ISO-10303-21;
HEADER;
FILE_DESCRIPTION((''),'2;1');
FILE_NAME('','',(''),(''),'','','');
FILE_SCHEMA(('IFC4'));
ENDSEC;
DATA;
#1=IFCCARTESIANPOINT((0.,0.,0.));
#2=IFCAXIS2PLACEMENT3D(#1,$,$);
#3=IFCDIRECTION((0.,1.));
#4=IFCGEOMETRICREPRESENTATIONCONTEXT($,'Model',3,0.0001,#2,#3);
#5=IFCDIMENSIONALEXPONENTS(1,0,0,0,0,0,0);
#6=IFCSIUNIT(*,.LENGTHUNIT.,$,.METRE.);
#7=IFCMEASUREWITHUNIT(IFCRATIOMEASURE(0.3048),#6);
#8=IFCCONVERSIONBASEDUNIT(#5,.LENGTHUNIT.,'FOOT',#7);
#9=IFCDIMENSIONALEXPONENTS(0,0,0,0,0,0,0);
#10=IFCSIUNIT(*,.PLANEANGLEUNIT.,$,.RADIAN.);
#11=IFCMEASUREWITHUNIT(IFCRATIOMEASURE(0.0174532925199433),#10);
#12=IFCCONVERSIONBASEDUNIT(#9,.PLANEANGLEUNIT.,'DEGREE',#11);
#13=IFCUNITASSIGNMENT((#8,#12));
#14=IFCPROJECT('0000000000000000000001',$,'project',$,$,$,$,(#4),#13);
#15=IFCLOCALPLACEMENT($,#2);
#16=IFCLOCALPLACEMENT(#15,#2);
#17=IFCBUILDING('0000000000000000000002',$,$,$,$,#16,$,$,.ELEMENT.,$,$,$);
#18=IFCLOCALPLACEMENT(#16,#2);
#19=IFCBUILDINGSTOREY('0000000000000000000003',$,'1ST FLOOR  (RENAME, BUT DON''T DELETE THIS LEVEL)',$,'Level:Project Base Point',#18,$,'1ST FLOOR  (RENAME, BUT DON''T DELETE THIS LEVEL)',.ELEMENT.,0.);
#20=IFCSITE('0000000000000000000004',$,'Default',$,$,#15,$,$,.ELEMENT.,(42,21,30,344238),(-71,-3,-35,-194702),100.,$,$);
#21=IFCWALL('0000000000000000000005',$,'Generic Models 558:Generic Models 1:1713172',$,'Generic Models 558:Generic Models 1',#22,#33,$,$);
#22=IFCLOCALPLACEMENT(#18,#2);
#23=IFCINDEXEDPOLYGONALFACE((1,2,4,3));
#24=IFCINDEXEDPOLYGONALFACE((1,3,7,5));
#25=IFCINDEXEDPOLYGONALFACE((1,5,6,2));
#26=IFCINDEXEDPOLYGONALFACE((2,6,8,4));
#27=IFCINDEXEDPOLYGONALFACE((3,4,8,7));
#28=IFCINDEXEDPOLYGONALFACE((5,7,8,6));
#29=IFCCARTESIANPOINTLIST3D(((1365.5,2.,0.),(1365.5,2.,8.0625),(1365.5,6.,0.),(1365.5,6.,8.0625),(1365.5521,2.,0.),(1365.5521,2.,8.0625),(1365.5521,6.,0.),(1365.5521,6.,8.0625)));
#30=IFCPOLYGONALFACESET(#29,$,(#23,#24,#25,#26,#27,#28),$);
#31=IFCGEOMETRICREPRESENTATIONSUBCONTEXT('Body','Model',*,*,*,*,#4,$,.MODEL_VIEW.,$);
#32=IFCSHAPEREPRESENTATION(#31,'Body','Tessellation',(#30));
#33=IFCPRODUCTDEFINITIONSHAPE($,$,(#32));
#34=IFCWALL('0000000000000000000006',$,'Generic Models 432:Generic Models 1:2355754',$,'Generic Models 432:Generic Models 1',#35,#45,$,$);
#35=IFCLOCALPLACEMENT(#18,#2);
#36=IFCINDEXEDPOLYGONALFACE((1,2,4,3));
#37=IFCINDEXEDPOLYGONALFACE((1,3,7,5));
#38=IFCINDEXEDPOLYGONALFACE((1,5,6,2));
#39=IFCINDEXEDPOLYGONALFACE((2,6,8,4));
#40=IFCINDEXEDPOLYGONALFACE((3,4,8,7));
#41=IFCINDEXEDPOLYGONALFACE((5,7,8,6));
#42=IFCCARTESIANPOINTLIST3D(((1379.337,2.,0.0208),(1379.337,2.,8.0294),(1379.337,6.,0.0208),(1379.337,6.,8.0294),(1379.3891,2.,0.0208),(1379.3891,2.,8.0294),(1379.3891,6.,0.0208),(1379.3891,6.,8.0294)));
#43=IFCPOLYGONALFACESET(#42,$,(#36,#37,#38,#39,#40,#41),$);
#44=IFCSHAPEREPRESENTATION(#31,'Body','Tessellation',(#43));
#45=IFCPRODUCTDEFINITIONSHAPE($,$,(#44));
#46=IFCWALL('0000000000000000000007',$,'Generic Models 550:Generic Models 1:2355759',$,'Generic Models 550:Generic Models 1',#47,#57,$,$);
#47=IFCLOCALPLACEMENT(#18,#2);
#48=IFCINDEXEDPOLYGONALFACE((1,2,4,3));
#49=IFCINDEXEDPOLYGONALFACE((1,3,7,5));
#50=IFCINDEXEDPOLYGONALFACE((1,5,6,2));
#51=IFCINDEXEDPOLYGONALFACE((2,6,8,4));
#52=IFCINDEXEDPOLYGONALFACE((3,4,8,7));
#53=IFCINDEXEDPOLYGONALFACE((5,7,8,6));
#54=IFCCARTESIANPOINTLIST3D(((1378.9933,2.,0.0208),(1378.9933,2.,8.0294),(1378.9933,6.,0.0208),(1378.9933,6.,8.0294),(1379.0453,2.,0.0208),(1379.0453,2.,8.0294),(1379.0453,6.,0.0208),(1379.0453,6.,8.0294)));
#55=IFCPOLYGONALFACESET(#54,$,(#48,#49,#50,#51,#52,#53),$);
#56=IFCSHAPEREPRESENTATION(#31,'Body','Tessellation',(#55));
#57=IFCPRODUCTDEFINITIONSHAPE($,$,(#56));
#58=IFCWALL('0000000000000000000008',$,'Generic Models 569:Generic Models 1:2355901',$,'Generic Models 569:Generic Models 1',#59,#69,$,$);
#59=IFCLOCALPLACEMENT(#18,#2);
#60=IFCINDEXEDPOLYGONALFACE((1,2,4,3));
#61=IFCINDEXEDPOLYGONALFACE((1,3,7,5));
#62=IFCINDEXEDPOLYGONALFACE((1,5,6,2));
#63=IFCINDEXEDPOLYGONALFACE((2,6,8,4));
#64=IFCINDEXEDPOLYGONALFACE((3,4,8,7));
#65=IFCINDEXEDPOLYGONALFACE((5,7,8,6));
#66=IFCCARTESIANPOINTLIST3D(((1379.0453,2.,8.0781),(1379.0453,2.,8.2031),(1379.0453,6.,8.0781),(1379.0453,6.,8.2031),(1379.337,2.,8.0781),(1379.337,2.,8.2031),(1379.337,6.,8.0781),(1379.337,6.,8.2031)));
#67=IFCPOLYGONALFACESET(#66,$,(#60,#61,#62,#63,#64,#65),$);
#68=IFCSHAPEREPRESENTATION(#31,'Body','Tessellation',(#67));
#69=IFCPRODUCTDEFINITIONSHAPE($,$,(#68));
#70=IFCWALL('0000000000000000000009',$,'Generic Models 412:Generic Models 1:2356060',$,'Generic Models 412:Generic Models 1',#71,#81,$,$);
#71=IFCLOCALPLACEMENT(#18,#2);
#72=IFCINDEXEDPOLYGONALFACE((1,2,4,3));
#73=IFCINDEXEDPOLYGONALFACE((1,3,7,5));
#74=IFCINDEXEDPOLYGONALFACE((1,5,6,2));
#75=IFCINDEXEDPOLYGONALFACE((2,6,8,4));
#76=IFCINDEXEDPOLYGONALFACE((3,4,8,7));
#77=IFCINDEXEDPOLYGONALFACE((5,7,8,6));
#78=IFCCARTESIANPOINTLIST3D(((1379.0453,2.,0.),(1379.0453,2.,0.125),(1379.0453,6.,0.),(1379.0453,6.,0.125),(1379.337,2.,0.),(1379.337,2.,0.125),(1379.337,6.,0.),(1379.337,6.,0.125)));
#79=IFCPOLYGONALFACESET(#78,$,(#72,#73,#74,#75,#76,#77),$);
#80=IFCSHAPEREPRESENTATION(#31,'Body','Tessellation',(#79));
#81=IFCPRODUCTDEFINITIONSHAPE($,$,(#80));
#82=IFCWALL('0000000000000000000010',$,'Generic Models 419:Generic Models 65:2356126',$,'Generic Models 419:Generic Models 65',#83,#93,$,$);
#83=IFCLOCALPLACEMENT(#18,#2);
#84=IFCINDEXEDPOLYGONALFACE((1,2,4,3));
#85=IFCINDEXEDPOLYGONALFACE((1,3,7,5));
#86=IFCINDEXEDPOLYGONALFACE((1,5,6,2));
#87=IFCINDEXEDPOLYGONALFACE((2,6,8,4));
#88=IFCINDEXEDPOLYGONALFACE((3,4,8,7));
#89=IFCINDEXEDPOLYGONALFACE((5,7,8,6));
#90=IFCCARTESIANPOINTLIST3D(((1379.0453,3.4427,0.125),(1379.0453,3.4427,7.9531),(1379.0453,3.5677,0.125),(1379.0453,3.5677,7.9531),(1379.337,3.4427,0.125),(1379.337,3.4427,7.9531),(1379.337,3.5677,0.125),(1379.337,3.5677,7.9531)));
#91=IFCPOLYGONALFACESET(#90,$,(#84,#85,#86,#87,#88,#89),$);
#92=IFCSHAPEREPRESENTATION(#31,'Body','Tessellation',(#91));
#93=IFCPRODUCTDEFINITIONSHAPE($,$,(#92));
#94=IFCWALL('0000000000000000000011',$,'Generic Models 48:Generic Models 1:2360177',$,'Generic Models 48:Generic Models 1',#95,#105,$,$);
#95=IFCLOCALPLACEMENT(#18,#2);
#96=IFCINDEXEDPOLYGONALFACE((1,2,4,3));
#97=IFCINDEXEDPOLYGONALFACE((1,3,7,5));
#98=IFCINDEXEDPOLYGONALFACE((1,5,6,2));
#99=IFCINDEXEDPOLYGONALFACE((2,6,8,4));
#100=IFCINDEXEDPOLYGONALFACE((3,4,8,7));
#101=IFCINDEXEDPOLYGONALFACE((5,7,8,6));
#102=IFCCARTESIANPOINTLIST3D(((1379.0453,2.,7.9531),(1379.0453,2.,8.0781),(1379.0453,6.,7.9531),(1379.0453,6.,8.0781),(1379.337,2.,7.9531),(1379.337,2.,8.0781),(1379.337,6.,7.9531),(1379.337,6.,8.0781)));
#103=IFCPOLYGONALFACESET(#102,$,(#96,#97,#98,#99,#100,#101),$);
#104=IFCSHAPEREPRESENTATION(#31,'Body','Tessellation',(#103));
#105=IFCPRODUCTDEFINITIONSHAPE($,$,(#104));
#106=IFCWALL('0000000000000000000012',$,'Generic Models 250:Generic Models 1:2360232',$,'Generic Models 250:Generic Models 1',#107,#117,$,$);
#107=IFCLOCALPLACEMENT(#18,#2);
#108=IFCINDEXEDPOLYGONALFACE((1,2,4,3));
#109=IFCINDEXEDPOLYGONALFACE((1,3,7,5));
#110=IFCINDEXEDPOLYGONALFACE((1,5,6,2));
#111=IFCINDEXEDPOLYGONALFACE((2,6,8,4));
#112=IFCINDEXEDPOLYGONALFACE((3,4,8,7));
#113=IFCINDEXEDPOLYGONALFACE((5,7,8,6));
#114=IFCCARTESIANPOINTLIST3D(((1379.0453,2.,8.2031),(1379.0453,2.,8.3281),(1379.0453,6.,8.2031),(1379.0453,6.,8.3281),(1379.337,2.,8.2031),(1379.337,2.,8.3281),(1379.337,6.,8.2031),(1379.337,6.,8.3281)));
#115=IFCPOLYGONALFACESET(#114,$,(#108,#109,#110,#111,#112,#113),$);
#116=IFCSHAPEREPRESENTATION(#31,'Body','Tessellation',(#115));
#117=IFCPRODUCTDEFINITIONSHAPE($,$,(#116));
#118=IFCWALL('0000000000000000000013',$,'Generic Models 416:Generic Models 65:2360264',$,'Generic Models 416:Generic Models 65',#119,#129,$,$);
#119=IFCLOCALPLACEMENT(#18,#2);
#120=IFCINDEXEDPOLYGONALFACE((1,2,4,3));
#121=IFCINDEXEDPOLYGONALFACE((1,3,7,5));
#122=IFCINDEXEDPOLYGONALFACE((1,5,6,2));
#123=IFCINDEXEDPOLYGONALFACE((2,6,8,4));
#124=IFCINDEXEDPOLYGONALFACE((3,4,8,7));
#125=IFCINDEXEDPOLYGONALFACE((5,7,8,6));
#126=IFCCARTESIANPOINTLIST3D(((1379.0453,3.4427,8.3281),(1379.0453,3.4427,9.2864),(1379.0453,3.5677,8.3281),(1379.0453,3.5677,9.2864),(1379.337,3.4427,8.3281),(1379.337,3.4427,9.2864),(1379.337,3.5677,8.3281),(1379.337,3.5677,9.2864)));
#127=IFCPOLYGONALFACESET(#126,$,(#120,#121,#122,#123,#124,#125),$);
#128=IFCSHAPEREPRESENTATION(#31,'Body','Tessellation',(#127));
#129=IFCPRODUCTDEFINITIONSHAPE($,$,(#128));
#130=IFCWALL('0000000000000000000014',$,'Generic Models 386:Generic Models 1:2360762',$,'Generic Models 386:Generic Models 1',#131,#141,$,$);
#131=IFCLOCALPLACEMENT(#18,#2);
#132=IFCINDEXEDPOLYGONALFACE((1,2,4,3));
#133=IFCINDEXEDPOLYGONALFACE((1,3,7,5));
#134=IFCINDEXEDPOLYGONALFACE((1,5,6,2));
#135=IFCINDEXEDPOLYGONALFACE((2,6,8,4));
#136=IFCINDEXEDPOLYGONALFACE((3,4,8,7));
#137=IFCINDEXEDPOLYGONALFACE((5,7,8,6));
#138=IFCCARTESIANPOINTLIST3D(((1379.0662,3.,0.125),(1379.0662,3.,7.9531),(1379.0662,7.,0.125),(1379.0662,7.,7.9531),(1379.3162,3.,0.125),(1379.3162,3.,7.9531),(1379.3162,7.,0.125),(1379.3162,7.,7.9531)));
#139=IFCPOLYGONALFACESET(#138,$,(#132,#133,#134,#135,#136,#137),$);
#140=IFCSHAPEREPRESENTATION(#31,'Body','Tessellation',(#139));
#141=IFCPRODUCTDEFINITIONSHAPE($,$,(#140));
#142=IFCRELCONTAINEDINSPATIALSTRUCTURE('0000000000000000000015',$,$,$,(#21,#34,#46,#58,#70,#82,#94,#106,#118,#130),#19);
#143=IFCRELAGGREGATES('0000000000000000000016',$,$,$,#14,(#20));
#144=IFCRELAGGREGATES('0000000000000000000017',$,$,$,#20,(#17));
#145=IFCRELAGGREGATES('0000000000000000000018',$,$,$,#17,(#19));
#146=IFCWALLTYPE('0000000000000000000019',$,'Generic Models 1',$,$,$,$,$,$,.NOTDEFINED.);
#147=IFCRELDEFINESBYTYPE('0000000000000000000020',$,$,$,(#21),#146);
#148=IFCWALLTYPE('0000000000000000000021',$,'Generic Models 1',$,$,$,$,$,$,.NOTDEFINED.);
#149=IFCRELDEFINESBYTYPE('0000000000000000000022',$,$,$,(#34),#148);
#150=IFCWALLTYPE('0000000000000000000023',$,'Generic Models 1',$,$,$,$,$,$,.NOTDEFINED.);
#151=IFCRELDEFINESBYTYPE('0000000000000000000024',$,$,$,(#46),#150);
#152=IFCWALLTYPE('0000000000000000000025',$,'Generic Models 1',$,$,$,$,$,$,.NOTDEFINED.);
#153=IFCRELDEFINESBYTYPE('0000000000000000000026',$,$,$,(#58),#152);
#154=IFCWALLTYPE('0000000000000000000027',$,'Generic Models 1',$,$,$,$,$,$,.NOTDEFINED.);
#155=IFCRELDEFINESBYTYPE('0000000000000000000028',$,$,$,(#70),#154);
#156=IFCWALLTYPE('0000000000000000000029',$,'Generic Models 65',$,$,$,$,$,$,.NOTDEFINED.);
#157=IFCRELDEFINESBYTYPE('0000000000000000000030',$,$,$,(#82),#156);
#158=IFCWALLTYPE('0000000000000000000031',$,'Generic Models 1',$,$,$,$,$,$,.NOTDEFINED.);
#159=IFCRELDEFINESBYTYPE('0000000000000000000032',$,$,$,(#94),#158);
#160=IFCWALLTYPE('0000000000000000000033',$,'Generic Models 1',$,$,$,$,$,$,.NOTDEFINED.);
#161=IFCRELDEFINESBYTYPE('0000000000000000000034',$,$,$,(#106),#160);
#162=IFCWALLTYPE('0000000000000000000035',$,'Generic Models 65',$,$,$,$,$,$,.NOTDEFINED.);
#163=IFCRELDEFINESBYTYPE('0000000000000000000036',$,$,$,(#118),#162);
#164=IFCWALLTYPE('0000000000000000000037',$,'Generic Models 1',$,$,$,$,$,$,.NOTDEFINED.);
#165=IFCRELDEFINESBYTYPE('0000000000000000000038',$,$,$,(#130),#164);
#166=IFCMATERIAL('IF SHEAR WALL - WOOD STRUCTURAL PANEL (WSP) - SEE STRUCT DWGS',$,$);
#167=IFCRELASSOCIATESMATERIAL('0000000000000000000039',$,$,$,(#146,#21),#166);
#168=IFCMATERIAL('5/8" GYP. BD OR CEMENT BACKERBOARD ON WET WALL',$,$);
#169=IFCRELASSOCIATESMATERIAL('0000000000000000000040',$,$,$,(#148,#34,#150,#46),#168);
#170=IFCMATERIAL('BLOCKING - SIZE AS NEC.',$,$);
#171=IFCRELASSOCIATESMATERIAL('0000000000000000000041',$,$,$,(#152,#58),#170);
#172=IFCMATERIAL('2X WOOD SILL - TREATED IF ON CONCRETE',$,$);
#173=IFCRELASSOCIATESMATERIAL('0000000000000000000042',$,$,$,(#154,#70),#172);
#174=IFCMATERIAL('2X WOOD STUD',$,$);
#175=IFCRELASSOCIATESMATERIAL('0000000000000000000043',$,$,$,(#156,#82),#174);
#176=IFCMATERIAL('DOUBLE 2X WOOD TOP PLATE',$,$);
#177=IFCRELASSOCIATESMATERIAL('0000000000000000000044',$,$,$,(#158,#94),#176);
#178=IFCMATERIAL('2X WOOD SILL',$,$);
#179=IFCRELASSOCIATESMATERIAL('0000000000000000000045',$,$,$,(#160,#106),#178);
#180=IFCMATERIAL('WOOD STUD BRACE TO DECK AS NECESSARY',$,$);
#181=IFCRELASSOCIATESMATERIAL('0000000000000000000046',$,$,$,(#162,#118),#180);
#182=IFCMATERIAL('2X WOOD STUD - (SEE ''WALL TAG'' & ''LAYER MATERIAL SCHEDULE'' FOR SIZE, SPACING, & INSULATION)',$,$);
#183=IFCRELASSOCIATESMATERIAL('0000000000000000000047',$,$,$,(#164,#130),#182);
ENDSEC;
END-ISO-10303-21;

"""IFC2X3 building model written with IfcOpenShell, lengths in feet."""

from ifc_helpers import new_model, entity, si_unit, converted_unit, direction, frame, frame_2d, origin, place, context, subcontext, project, spatial, rectangle, extrude, material, type_object, element, save


model = new_model("IFC2X3")

# Units and contexts
model_context = context("Model", 3, precision=0.0001, world=origin(), true_north=direction((0.0, 1.0)))
body_context = subcontext(model_context, "Body", "Model", "MODEL_VIEW")
ifc_project = project(units=[converted_unit("LENGTHUNIT", "FOOT", entity("IfcRatioMeasure", 0.3048), si_unit("LENGTHUNIT", "METRE"), dimensions=[1, 0, 0, 0, 0, 0, 0]), converted_unit("PLANEANGLEUNIT", "DEGREE", entity("IfcRatioMeasure", 0.0174532925199433), si_unit("PLANEANGLEUNIT", "RADIAN"), dimensions=[0, 0, 0, 0, 0, 0, 0])], contexts=[model_context])

# Site, building, storey
site_placement = place(None, origin())
site = spatial("IfcSite", under=ifc_project, at=site_placement, Name="Default", CompositionType="ELEMENT", RefLatitude=(42, 21, 30, 344238), RefLongitude=(-71, -3, -35, -194702), RefElevation=100.0)
building_placement = place(site_placement, origin())
building = spatial("IfcBuilding", under=site, at=building_placement, CompositionType="ELEMENT")
storey_placement = place(building_placement, origin())
storey = spatial("IfcBuildingStorey", under=building, at=storey_placement, Name="1ST FLOOR  (RENAME, BUT DON'T DELETE THIS LEVEL)", ObjectType="Level:Project Base Point", LongName="1ST FLOOR  (RENAME, BUT DON'T DELETE THIS LEVEL)", CompositionType="ELEMENT", Elevation=0.0)

# Walls
ifc_material_1 = material(Name="2X WOOD SILL - TREATED IF ON CONCRETE")
ifc_material_2 = material(Name="5/8\" GYP. BD OR CEMENT BACKERBOARD ON WET WALL")
ifc_material_3 = material(Name="2X WOOD STUD")
ifc_material_4 = material(Name="DOUBLE 2X WOOD TOP PLATE")
ifc_material_5 = material(Name="2X WOOD STUD - (SEE 'WALL TAG' & 'LAYER MATERIAL SCHEDULE' FOR SIZE, SPACING, & INSULATION)")
ifc_material_6 = material(Name="IF SHEAR WALL - WOOD STRUCTURAL PANEL (WSP) - SEE STRUCT DWGS")
wall_type_1 = type_object("IfcWallType", Name="Generic Models 1", PredefinedType="NOTDEFINED", material=ifc_material_6)
wall_1_placement = place(storey_placement, frame((1365.5, 2.0, 0.0), z_axis=(0.0, 0.0, 1.0), x_axis=(0.0, 1.0, 0.0)))
element("IfcWall", 1, at=wall_1_placement, inside=storey, type_object=wall_type_1, material=ifc_material_6, Name="Generic Models 558:Generic Models 1:1713172", ObjectType="Generic Models 558:Generic Models 1", context=body_context, shape_type="SweptSolid", body=[
    extrude(rectangle(XDim=4.0, YDim=0.0521, at=frame_2d((0.0, 0.0), x_axis=(1.0, 0.0))), frame((2.0, -0.026, 0.0)), (0.0, 0.0, 1.0), 8.0625),
])
wall_type_2 = type_object("IfcWallType", Name="Generic Models 1", PredefinedType="NOTDEFINED", material=ifc_material_2)
wall_2_placement = place(storey_placement, frame((1379.337, 2.0, 0.0208), z_axis=(0.0, 0.0, 1.0), x_axis=(0.0, 1.0, 0.0)))
element("IfcWall", 2, at=wall_2_placement, inside=storey, type_object=wall_type_2, material=ifc_material_2, Name="Generic Models 432:Generic Models 1:2355754", ObjectType="Generic Models 432:Generic Models 1", context=body_context, shape_type="SweptSolid", body=[
    extrude(rectangle(XDim=4.0, YDim=0.0521, at=frame_2d((0.0, 0.0), x_axis=(1.0, 0.0))), frame((2.0, -0.026, 0.0)), (0.0, 0.0, 1.0), 8.0086),
])
wall_type_3 = type_object("IfcWallType", Name="Generic Models 1", PredefinedType="NOTDEFINED", material=ifc_material_2)
wall_3_placement = place(storey_placement, frame((1378.9932, 2.0, 0.0208), z_axis=(0.0, 0.0, 1.0), x_axis=(0.0, 1.0, 0.0)))
element("IfcWall", 3, at=wall_3_placement, inside=storey, type_object=wall_type_3, material=ifc_material_2, Name="Generic Models 550:Generic Models 1:2355759", ObjectType="Generic Models 550:Generic Models 1", context=body_context, shape_type="SweptSolid", body=[
    extrude(rectangle(XDim=4.0, YDim=0.0521, at=frame_2d((0.0, 0.0), x_axis=(1.0, 0.0))), frame((2.0, -0.026, 0.0)), (0.0, 0.0, 1.0), 8.0086),
])
ifc_material_7 = material(Name="BLOCKING - SIZE AS NEC.")
wall_type_4 = type_object("IfcWallType", Name="Generic Models 1", PredefinedType="NOTDEFINED", material=ifc_material_7)
wall_4_placement = place(storey_placement, frame((1379.0453, 2.0, 8.0781), z_axis=(0.0, 0.0, 1.0), x_axis=(0.0, 1.0, 0.0)))
element("IfcWall", 4, at=wall_4_placement, inside=storey, type_object=wall_type_4, material=ifc_material_7, Name="Generic Models 569:Generic Models 1:2355901", ObjectType="Generic Models 569:Generic Models 1", context=body_context, shape_type="SweptSolid", body=[
    extrude(rectangle(XDim=4.0, YDim=0.2917, at=frame_2d((0.0, 0.0), x_axis=(1.0, 0.0))), frame((2.0, -0.1458, 0.0)), (0.0, 0.0, 1.0), 0.125),
])
wall_type_5 = type_object("IfcWallType", Name="Generic Models 1", PredefinedType="NOTDEFINED", material=ifc_material_1)
wall_5_placement = place(storey_placement, frame((1379.0453, 2.0, 0.0), z_axis=(0.0, 0.0, 1.0), x_axis=(0.0, 1.0, 0.0)))
element("IfcWall", 5, at=wall_5_placement, inside=storey, type_object=wall_type_5, material=ifc_material_1, Name="Generic Models 412:Generic Models 1:2356060", ObjectType="Generic Models 412:Generic Models 1", context=body_context, shape_type="SweptSolid", body=[
    extrude(rectangle(XDim=4.0, YDim=0.2917, at=frame_2d((0.0, 0.0), x_axis=(1.0, 0.0))), frame((2.0, -0.1458, 0.0)), (0.0, 0.0, 1.0), 0.125),
])
wall_type_6 = type_object("IfcWallType", Name="Generic Models 65", PredefinedType="NOTDEFINED", material=ifc_material_3)
wall_6_placement = place(storey_placement, frame((1379.0453, 3.4427, 0.125)))
element("IfcWall", 6, at=wall_6_placement, inside=storey, type_object=wall_type_6, material=ifc_material_3, Name="Generic Models 419:Generic Models 65:2356126", ObjectType="Generic Models 419:Generic Models 65", context=body_context, shape_type="SweptSolid", body=[
    extrude(rectangle(XDim=0.125, YDim=0.2917, at=frame_2d((0.0, 0.0), x_axis=(1.0, 0.0))), frame((0.1458, 0.0625, 0.0), z_axis=(0.0, 0.0, 1.0), x_axis=(0.0, 1.0, 0.0)), (0.0, 0.0, 1.0), 7.8281),
])
wall_type_7 = type_object("IfcWallType", Name="Generic Models 1", PredefinedType="NOTDEFINED", material=ifc_material_4)
wall_7_placement = place(storey_placement, frame((1379.0453, 2.0, 7.9531), z_axis=(0.0, 0.0, 1.0), x_axis=(0.0, 1.0, 0.0)))
element("IfcWall", 7, at=wall_7_placement, inside=storey, type_object=wall_type_7, material=ifc_material_4, Name="Generic Models 48:Generic Models 1:2360177", ObjectType="Generic Models 48:Generic Models 1", context=body_context, shape_type="SweptSolid", body=[
    extrude(rectangle(XDim=4.0, YDim=0.2917, at=frame_2d((0.0, 0.0), x_axis=(1.0, 0.0))), frame((2.0, -0.1458, 0.0)), (0.0, 0.0, 1.0), 0.125),
])
ifc_material_8 = material(Name="2X WOOD SILL")
wall_type_8 = type_object("IfcWallType", Name="Generic Models 1", PredefinedType="NOTDEFINED", material=ifc_material_8)
wall_8_placement = place(storey_placement, frame((1379.0453, 2.0, 8.2031), z_axis=(0.0, 0.0, 1.0), x_axis=(0.0, 1.0, 0.0)))
element("IfcWall", 8, at=wall_8_placement, inside=storey, type_object=wall_type_8, material=ifc_material_8, Name="Generic Models 250:Generic Models 1:2360232", ObjectType="Generic Models 250:Generic Models 1", context=body_context, shape_type="SweptSolid", body=[
    extrude(rectangle(XDim=4.0, YDim=0.2917, at=frame_2d((0.0, 0.0), x_axis=(1.0, 0.0))), frame((2.0, -0.1458, 0.0)), (0.0, 0.0, 1.0), 0.125),
])
ifc_material_9 = material(Name="WOOD STUD BRACE TO DECK AS NECESSARY")
wall_type_9 = type_object("IfcWallType", Name="Generic Models 65", PredefinedType="NOTDEFINED", material=ifc_material_9)
wall_9_placement = place(storey_placement, frame((1379.0453, 3.4427, 8.3281)))
element("IfcWall", 9, at=wall_9_placement, inside=storey, type_object=wall_type_9, material=ifc_material_9, Name="Generic Models 416:Generic Models 65:2360264", ObjectType="Generic Models 416:Generic Models 65", context=body_context, shape_type="SweptSolid", body=[
    extrude(rectangle(XDim=0.125, YDim=0.2917, at=frame_2d((0.0, 0.0), x_axis=(1.0, 0.0))), frame((0.1458, 0.0625, 0.0), z_axis=(0.0, 0.0, 1.0), x_axis=(0.0, 1.0, 0.0)), (0.0, 0.0, 1.0), 0.9583),
])
wall_type_10 = type_object("IfcWallType", Name="Generic Models 1", PredefinedType="NOTDEFINED", material=ifc_material_5)
wall_10_placement = place(storey_placement, frame((1379.0662, 3.0, 0.125), z_axis=(0.0, 0.0, 1.0), x_axis=(0.0, 1.0, 0.0)))
element("IfcWall", 10, at=wall_10_placement, inside=storey, type_object=wall_type_10, material=ifc_material_5, Name="Generic Models 386:Generic Models 1:2360762", ObjectType="Generic Models 386:Generic Models 1", context=body_context, shape_type="SweptSolid", body=[
    extrude(rectangle(XDim=4.0, YDim=0.25, at=frame_2d((0.0, 0.0), x_axis=(1.0, 0.0))), frame((2.0, -0.125, 0.0)), (0.0, 0.0, 1.0), 7.8281),
])

save(model, "model.ifc")
